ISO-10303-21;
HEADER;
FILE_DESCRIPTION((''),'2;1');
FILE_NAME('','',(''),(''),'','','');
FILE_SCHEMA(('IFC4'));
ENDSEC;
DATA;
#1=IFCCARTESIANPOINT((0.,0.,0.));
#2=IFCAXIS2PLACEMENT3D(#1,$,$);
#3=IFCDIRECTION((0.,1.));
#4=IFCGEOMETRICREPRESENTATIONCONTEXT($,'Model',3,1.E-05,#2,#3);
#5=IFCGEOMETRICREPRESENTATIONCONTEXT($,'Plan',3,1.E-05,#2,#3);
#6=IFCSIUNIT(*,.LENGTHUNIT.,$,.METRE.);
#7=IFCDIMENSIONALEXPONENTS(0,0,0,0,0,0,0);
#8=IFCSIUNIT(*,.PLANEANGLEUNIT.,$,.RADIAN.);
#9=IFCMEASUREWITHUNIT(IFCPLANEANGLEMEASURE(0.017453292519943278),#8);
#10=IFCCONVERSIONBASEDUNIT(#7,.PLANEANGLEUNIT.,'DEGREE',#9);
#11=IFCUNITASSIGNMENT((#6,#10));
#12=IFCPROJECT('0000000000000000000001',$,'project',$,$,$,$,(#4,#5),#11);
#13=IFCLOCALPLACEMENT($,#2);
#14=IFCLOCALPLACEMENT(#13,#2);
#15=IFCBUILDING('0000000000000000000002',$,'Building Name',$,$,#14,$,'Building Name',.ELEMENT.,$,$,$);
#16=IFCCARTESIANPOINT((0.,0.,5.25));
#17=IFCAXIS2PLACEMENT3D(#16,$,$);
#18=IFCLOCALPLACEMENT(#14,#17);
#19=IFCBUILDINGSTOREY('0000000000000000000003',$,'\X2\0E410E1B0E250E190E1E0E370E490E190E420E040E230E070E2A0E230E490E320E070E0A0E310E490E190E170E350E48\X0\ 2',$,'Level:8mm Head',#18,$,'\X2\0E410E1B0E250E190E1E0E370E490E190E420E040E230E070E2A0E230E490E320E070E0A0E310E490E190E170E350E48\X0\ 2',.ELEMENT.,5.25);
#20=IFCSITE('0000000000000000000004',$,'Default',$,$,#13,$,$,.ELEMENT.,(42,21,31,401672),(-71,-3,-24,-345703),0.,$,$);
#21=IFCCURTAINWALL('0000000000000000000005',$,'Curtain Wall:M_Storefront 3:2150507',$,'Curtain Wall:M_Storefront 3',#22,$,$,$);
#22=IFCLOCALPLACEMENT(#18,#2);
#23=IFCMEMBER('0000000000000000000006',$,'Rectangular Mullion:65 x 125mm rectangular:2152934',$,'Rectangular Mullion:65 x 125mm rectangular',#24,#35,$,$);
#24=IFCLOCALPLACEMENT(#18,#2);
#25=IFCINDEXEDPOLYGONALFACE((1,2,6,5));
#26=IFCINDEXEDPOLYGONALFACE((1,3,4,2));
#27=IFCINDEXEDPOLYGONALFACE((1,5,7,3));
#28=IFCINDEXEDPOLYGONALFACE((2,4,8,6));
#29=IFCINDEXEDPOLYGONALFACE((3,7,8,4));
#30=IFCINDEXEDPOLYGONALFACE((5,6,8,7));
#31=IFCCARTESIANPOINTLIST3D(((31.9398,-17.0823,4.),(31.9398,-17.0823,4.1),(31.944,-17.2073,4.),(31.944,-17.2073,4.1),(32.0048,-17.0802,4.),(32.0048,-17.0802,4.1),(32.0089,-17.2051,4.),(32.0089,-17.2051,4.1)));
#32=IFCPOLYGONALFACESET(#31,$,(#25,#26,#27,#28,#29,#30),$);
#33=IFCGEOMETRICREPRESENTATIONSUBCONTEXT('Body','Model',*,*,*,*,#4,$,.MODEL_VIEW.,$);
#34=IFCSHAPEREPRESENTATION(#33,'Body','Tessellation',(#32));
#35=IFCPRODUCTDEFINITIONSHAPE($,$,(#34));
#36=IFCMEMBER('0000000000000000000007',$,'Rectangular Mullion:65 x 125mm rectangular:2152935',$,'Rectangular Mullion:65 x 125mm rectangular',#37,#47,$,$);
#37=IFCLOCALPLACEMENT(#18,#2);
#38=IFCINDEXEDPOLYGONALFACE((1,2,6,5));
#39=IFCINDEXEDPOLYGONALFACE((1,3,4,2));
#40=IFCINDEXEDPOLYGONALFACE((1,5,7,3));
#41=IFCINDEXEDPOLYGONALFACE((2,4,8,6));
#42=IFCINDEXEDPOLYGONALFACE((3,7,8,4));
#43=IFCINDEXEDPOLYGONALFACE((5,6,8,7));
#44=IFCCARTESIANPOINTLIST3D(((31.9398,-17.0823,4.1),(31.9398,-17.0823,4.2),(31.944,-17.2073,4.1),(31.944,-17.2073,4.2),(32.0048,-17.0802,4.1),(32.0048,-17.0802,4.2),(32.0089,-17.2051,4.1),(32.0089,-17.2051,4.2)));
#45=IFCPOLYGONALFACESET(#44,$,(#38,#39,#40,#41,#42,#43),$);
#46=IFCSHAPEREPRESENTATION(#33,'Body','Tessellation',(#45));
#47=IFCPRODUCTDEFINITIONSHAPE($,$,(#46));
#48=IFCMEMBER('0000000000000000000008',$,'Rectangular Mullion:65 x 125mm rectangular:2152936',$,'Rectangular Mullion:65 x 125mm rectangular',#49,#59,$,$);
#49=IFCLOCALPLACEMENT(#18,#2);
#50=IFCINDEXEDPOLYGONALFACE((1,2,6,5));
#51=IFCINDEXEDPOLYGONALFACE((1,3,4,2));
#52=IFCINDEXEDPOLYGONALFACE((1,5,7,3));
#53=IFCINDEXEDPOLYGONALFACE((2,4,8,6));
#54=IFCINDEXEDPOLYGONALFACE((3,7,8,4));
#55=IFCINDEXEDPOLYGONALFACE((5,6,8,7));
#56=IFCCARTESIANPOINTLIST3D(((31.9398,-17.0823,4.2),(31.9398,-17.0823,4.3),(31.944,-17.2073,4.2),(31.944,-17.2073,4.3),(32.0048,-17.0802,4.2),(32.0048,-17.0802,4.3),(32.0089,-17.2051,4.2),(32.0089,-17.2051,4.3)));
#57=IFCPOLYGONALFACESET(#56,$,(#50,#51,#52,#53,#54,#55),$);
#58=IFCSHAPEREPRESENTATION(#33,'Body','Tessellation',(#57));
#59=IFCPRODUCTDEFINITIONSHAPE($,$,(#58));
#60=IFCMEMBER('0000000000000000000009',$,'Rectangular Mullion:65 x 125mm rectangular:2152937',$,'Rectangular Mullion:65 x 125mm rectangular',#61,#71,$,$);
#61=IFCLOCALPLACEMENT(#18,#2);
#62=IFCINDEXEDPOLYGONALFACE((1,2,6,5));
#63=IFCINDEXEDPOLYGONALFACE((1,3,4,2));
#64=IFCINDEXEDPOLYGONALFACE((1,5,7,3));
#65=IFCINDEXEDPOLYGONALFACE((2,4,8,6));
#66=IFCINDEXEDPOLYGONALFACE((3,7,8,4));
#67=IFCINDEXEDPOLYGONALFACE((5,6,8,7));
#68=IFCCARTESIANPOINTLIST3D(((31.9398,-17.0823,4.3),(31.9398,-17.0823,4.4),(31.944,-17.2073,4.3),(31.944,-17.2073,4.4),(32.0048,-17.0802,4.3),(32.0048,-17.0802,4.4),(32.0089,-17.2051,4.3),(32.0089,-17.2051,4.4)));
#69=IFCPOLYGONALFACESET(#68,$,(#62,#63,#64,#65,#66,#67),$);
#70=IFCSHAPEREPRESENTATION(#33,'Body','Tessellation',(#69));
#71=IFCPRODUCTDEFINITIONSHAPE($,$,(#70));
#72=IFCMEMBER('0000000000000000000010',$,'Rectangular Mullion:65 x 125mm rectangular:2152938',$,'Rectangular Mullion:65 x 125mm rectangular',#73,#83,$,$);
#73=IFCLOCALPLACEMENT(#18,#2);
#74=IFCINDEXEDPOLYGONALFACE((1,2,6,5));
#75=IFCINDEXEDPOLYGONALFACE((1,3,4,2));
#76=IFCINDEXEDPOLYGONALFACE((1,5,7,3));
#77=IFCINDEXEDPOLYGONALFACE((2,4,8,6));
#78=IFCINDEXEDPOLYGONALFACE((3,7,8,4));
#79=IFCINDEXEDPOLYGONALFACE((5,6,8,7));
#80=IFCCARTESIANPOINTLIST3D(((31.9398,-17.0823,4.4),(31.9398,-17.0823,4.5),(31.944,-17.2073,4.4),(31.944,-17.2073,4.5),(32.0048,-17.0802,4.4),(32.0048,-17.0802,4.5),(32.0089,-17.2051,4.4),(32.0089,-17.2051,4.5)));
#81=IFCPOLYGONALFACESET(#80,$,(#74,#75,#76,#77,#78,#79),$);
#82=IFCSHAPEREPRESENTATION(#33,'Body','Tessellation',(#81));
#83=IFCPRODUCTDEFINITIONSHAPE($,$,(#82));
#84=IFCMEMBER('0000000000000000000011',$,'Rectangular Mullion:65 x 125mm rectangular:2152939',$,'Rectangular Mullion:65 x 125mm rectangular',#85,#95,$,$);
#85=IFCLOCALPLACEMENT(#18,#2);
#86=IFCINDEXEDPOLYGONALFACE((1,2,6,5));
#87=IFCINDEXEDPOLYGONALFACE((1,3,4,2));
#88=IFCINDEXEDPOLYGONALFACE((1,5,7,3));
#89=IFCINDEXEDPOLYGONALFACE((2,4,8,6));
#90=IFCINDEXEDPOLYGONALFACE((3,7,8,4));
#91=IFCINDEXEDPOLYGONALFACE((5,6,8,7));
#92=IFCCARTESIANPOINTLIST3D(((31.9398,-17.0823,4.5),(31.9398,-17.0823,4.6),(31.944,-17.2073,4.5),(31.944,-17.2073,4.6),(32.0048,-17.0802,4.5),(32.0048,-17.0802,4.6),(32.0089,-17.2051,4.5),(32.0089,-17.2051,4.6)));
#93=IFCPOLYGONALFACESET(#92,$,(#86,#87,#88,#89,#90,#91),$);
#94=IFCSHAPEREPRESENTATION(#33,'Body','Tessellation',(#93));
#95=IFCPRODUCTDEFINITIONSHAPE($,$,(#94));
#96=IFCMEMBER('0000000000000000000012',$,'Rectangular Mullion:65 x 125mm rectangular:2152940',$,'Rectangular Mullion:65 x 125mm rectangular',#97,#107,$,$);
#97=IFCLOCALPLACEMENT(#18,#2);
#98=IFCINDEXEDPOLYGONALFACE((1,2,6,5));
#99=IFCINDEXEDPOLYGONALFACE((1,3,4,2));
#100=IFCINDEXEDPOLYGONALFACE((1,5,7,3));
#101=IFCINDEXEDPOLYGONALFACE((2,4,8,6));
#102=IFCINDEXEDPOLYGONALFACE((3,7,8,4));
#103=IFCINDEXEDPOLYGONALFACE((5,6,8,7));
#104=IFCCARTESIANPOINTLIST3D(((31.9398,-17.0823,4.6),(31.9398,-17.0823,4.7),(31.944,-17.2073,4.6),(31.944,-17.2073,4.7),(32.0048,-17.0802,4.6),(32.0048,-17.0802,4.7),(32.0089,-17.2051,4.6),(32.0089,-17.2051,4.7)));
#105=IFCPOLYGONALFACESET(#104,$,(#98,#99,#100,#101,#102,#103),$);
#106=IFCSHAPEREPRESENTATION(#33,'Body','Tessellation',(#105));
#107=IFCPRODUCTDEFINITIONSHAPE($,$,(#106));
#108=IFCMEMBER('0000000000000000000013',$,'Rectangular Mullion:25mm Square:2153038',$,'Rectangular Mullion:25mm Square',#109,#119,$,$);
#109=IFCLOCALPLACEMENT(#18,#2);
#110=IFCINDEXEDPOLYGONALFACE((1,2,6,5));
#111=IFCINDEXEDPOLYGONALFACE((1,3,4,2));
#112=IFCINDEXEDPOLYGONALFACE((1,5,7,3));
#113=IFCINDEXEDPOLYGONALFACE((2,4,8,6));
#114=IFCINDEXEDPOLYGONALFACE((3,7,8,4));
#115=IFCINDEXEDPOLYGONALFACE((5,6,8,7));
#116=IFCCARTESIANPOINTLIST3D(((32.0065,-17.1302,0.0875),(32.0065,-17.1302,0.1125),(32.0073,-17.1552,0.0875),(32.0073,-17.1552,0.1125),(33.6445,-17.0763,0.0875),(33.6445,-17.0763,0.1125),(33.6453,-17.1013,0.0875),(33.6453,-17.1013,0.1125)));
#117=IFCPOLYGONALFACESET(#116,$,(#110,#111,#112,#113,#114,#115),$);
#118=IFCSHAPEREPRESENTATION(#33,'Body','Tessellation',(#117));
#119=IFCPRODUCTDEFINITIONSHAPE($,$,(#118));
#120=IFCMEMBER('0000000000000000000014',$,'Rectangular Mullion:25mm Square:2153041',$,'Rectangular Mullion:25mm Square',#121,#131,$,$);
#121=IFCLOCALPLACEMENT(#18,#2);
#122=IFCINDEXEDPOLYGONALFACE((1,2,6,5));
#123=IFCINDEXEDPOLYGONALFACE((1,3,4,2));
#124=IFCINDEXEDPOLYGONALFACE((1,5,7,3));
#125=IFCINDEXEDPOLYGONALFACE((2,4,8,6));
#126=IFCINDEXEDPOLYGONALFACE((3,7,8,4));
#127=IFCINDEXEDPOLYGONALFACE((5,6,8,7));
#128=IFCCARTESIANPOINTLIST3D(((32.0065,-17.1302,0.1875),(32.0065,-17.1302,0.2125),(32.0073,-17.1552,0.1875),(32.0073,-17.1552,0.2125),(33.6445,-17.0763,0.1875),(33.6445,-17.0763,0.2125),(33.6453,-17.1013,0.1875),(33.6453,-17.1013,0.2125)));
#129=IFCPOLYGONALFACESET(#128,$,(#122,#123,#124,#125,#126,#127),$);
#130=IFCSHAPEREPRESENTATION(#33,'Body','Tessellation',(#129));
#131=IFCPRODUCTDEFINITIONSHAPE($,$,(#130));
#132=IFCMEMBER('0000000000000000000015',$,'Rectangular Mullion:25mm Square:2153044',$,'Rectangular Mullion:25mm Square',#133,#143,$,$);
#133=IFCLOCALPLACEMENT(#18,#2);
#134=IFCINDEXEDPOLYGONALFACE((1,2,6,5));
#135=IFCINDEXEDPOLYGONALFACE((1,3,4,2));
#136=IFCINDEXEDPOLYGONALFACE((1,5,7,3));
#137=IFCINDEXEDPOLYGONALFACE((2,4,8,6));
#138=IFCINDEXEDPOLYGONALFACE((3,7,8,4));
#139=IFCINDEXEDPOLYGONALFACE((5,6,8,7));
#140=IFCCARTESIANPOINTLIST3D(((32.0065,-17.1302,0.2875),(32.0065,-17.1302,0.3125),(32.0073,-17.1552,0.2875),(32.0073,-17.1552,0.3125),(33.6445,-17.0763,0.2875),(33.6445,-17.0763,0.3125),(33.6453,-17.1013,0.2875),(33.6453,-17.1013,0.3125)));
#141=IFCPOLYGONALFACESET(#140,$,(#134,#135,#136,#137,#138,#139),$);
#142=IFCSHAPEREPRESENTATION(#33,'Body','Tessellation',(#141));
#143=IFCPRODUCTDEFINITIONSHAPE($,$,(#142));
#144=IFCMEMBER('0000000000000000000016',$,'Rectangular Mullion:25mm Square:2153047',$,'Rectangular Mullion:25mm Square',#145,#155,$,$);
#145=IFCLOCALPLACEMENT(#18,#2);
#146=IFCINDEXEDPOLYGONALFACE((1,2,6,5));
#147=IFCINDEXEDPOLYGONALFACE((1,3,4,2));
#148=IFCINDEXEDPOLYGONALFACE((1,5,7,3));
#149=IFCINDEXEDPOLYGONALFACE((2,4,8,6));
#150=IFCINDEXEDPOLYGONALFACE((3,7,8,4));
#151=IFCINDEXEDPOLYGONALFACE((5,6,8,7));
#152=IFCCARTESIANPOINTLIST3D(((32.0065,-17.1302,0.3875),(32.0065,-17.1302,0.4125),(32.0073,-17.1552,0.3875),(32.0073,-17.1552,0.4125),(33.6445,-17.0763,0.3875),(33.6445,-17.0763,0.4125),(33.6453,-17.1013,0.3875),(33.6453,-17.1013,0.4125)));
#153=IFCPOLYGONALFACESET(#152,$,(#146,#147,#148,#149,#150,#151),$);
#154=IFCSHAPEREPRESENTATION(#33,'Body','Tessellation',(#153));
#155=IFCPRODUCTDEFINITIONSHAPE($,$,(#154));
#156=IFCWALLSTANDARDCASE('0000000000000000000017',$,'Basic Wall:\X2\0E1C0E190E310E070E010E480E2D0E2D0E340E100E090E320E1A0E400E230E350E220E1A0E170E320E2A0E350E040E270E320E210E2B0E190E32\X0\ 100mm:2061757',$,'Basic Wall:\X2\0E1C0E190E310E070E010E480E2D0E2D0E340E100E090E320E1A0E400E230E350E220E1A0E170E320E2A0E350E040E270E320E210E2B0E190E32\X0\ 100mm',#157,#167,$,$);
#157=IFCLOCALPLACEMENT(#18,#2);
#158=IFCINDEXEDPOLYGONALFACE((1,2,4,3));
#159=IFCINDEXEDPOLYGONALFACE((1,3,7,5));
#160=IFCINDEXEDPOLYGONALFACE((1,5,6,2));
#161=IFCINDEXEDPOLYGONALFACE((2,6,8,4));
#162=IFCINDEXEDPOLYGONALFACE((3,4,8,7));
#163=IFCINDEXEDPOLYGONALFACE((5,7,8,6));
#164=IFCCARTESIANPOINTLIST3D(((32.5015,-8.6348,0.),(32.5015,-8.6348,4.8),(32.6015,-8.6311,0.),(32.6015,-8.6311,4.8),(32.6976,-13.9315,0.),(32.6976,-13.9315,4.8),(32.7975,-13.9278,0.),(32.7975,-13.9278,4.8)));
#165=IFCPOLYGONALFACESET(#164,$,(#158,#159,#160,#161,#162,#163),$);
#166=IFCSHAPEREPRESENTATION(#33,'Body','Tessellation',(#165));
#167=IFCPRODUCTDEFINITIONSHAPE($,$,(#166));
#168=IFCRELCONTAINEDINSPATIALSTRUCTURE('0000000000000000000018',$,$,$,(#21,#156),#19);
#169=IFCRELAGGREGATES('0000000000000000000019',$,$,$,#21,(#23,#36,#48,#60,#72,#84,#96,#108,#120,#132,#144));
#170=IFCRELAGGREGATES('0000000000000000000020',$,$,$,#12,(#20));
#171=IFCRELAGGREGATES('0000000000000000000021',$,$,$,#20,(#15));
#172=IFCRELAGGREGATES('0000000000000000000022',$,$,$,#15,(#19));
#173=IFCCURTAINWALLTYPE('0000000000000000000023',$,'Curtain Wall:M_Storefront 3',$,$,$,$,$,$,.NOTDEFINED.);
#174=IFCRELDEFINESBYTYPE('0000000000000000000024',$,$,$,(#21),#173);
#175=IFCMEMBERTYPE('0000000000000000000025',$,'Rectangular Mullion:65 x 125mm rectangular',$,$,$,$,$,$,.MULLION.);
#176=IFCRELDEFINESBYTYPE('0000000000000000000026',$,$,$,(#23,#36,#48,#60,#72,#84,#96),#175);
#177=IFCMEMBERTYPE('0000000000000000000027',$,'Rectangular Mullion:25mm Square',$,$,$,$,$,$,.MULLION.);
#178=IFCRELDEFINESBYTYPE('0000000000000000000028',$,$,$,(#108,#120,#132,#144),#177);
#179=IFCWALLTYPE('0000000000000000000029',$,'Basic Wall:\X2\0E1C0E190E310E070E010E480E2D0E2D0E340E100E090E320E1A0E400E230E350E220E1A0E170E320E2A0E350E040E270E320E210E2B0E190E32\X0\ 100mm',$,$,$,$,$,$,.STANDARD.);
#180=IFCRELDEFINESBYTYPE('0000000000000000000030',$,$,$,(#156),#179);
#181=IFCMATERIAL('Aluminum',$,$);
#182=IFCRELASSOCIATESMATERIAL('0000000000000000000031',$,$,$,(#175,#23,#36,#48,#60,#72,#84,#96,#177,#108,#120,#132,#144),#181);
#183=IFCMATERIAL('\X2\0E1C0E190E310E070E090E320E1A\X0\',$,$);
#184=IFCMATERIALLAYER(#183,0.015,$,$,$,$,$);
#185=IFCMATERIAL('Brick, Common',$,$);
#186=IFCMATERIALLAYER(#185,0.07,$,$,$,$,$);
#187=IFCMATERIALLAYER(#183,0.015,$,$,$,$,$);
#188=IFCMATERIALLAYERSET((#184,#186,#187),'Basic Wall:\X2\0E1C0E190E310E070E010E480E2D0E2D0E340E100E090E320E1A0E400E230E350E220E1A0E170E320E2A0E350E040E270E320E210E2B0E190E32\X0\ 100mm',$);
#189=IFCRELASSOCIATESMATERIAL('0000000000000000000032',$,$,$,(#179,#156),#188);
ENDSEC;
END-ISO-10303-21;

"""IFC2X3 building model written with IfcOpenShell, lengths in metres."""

from ifc_helpers import new_model, entity, si_unit, converted_unit, direction, frame, origin, origin_2d_with_axis, place, context, subcontext, project, spatial, polyline, rectangle, outline, extrude, source, transform, mapped, material, layer, layer_set, layer_usage, type_object, type_shapes, element, aggregate, save


model = new_model("IFC2X3")

# Units and contexts
model_context = context("Model", 3, precision=1e-05, world=origin(), true_north=direction((0.0, 1.0)))
plan_context = context("Plan", 3, precision=1e-05, world=origin(), true_north=direction((0.0, 1.0)))
body_context = subcontext(model_context, "Body", "Model", "MODEL_VIEW")
ifc_project = project(units=[si_unit("LENGTHUNIT", "METRE"), converted_unit("PLANEANGLEUNIT", "DEGREE", entity("IfcPlaneAngleMeasure", 0.017453292519943278), si_unit("PLANEANGLEUNIT", "RADIAN"), dimensions=[0, 0, 0, 0, 0, 0, 0])], contexts=[model_context, plan_context])

# Site, building, storey
site_placement = place(None, origin())
site = spatial("IfcSite", under=ifc_project, at=site_placement, Name="Default", CompositionType="ELEMENT", RefLatitude=(42, 21, 31, 401672), RefLongitude=(-71, -3, -24, -345703), RefElevation=0.0)
building_placement = place(site_placement, origin())
building = spatial("IfcBuilding", under=site, at=building_placement, Name="Building Name", LongName="Building Name", CompositionType="ELEMENT")
storey_placement = place(building_placement, frame((0.0, 0.0, 5.25)))
storey = spatial("IfcBuildingStorey", under=building, at=storey_placement, Name="แปลนพื้นโครงสร้างชั้นที่ 2", ObjectType="Level:8mm Head", LongName="แปลนพื้นโครงสร้างชั้นที่ 2", CompositionType="ELEMENT", Elevation=5.25)

# Curtain wall, members
curtain_wall_type = type_object("IfcCurtainWallType", Name="Curtain Wall:M_Storefront 3", PredefinedType="NOTDEFINED")
curtain_wall_placement = place(storey_placement, frame((0.0, 0.0, -5.25)))
curtain_wall = element("IfcCurtainWall", 1, at=curtain_wall_placement, inside=storey, type_object=curtain_wall_type, Name="Curtain Wall:M_Storefront 3:2150507", ObjectType="Curtain Wall:M_Storefront 3")
ifc_material_1 = material(Name="Aluminum")
member_type_1 = type_object("IfcMemberType", Name="Rectangular Mullion:65 x 125mm rectangular", PredefinedType="MULLION", material=ifc_material_1)
shared_shape_1 = source(origin(), body_context, "Body", "SweptSolid", [
    extrude(rectangle(XDim=0.065, YDim=0.125, at=origin_2d_with_axis()), frame((-0.0325, 0.0, -0.1), z_axis=(0.0, 0.0, 1.0), x_axis=(-1.0, 0.0, 0.0)), (0.0, 0.0, 1.0), 0.1),
])
type_shapes(member_type_1, [shared_shape_1])
member_1_placement = place(curtain_wall_placement, frame((31.9419, -17.1448, 9.35), z_axis=(0.0, 0.0, 1.0), x_axis=(-0.99946, -0.032862, 0.0)))
member_1 = element("IfcMember", 2, at=member_1_placement, type_object=member_type_1, material=ifc_material_1, Name="Rectangular Mullion:65 x 125mm rectangular:2152934", ObjectType="Rectangular Mullion:65 x 125mm rectangular", context=body_context, shape_type="MappedRepresentation", body=[
    mapped(shared_shape_1, transform((0.0, 0.0, 0.0), scale=1.0)),
])
member_2_placement = place(curtain_wall_placement, frame((31.9419, -17.1448, 9.45), z_axis=(0.0, 0.0, 1.0), x_axis=(-0.99946, -0.032862, 0.0)))
member_2 = element("IfcMember", 3, at=member_2_placement, type_object=member_type_1, material=ifc_material_1, Name="Rectangular Mullion:65 x 125mm rectangular:2152935", ObjectType="Rectangular Mullion:65 x 125mm rectangular", context=body_context, shape_type="MappedRepresentation", body=[
    mapped(shared_shape_1, transform((0.0, 0.0, 0.0), scale=1.0)),
])
member_3_placement = place(curtain_wall_placement, frame((31.9419, -17.1448, 9.55), z_axis=(0.0, 0.0, 1.0), x_axis=(-0.99946, -0.032862, 0.0)))
member_3 = element("IfcMember", 4, at=member_3_placement, type_object=member_type_1, material=ifc_material_1, Name="Rectangular Mullion:65 x 125mm rectangular:2152936", ObjectType="Rectangular Mullion:65 x 125mm rectangular", context=body_context, shape_type="MappedRepresentation", body=[
    mapped(shared_shape_1, transform((0.0, 0.0, 0.0), scale=1.0)),
])
member_4_placement = place(curtain_wall_placement, frame((31.9419, -17.1448, 9.65), z_axis=(0.0, 0.0, 1.0), x_axis=(-0.99946, -0.032862, 0.0)))
member_4 = element("IfcMember", 5, at=member_4_placement, type_object=member_type_1, material=ifc_material_1, Name="Rectangular Mullion:65 x 125mm rectangular:2152937", ObjectType="Rectangular Mullion:65 x 125mm rectangular", context=body_context, shape_type="MappedRepresentation", body=[
    mapped(shared_shape_1, transform((0.0, 0.0, 0.0), scale=1.0)),
])
member_5_placement = place(curtain_wall_placement, frame((31.9419, -17.1448, 9.75), z_axis=(0.0, 0.0, 1.0), x_axis=(-0.99946, -0.032862, 0.0)))
member_5 = element("IfcMember", 6, at=member_5_placement, type_object=member_type_1, material=ifc_material_1, Name="Rectangular Mullion:65 x 125mm rectangular:2152938", ObjectType="Rectangular Mullion:65 x 125mm rectangular", context=body_context, shape_type="MappedRepresentation", body=[
    mapped(shared_shape_1, transform((0.0, 0.0, 0.0), scale=1.0)),
])
member_6_placement = place(curtain_wall_placement, frame((31.9419, -17.1448, 9.85), z_axis=(0.0, 0.0, 1.0), x_axis=(-0.99946, -0.032862, 0.0)))
member_6 = element("IfcMember", 7, at=member_6_placement, type_object=member_type_1, material=ifc_material_1, Name="Rectangular Mullion:65 x 125mm rectangular:2152939", ObjectType="Rectangular Mullion:65 x 125mm rectangular", context=body_context, shape_type="MappedRepresentation", body=[
    mapped(shared_shape_1, transform((0.0, 0.0, 0.0), scale=1.0)),
])
member_7_placement = place(curtain_wall_placement, frame((31.9419, -17.1448, 9.95), z_axis=(0.0, 0.0, 1.0), x_axis=(-0.99946, -0.032862, 0.0)))
member_7 = element("IfcMember", 8, at=member_7_placement, type_object=member_type_1, material=ifc_material_1, Name="Rectangular Mullion:65 x 125mm rectangular:2152940", ObjectType="Rectangular Mullion:65 x 125mm rectangular", context=body_context, shape_type="MappedRepresentation", body=[
    mapped(shared_shape_1, transform((0.0, 0.0, 0.0), scale=1.0)),
])
member_type_2 = type_object("IfcMemberType", Name="Rectangular Mullion:25mm Square", PredefinedType="MULLION", material=ifc_material_1)
shared_shape_2 = source(origin(), body_context, "Body", "SweptSolid", [
    extrude(rectangle(XDim=0.025, YDim=0.025, at=origin_2d_with_axis()), frame((0.0, 0.0, -1.6389), z_axis=(0.0, 0.0, 1.0), x_axis=(-1.0, 0.0, 0.0)), (0.0, 0.0, 1.0), 1.6389),
])
type_shapes(member_type_2, [shared_shape_2])
member_8_placement = place(curtain_wall_placement, frame((33.6449, -17.0888, 5.35), z_axis=(0.99946, 0.032862, 0.0), x_axis=(0.0, 0.0, 1.0)))
member_8 = element("IfcMember", 9, at=member_8_placement, type_object=member_type_2, material=ifc_material_1, Name="Rectangular Mullion:25mm Square:2153038", ObjectType="Rectangular Mullion:25mm Square", context=body_context, shape_type="MappedRepresentation", body=[
    mapped(shared_shape_2, transform((0.0, 0.0, 0.0), scale=1.0)),
])
member_9_placement = place(curtain_wall_placement, frame((33.6449, -17.0888, 5.45), z_axis=(0.99946, 0.032862, 0.0), x_axis=(0.0, 0.0, 1.0)))
member_9 = element("IfcMember", 10, at=member_9_placement, type_object=member_type_2, material=ifc_material_1, Name="Rectangular Mullion:25mm Square:2153041", ObjectType="Rectangular Mullion:25mm Square", context=body_context, shape_type="MappedRepresentation", body=[
    mapped(shared_shape_2, transform((0.0, 0.0, 0.0), scale=1.0)),
])
member_10_placement = place(curtain_wall_placement, frame((33.6449, -17.0888, 5.55), z_axis=(0.99946, 0.032862, 0.0), x_axis=(0.0, 0.0, 1.0)))
member_10 = element("IfcMember", 11, at=member_10_placement, type_object=member_type_2, material=ifc_material_1, Name="Rectangular Mullion:25mm Square:2153044", ObjectType="Rectangular Mullion:25mm Square", context=body_context, shape_type="MappedRepresentation", body=[
    mapped(shared_shape_2, transform((0.0, 0.0, 0.0), scale=1.0)),
])
member_11_placement = place(curtain_wall_placement, frame((33.6449, -17.0888, 5.65), z_axis=(0.99946, 0.032862, 0.0), x_axis=(0.0, 0.0, 1.0)))
member_11 = element("IfcMember", 12, at=member_11_placement, type_object=member_type_2, material=ifc_material_1, Name="Rectangular Mullion:25mm Square:2153047", ObjectType="Rectangular Mullion:25mm Square", context=body_context, shape_type="MappedRepresentation", body=[
    mapped(shared_shape_2, transform((0.0, 0.0, 0.0), scale=1.0)),
])
aggregate(curtain_wall, [member_1, member_2, member_3, member_4, member_5, member_6, member_7, member_8, member_9, member_10, member_11])

# Wall
ifc_material_2 = material(Name="ผนังฉาบ")
ifc_layer_1 = layer(ifc_material_2, 0.015)
ifc_material_3 = material(Name="Brick, Common")
ifc_layer_2 = layer(ifc_material_3, 0.07)
ifc_layer_3 = layer(ifc_material_2, 0.015)
ifc_layer_set = layer_set([ifc_layer_1, ifc_layer_2, ifc_layer_3], Name="Basic Wall:ผนังก่ออิฐฉาบเรียบทาสีความหนา 100mm")
ifc_layer_usage = layer_usage(ifc_layer_set, "AXIS2", "NEGATIVE", 0.05)
wall_type = type_object("IfcWallType", Name="Basic Wall:ผนังก่ออิฐฉาบเรียบทาสีความหนา 100mm", PredefinedType="STANDARD", material=ifc_layer_set)
wall_placement = place(storey_placement, frame((32.7476, -13.9296, 0.0), z_axis=(0.0, 0.0, 1.0), x_axis=(-0.036993, 0.999316, 0.0)))
element("IfcWallStandardCase", 13, at=wall_placement, inside=storey, type_object=wall_type, material=ifc_layer_usage, Name="Basic Wall:ผนังก่ออิฐฉาบเรียบทาสีความหนา 100mm:2061757", ObjectType="Basic Wall:ผนังก่ออิฐฉาบเรียบทาสีความหนา 100mm", context=body_context, shape_type="SweptSolid", body=[
    extrude(outline(polyline([(5.3004, -0.05), (5.3003, 0.05), (0.0, 0.05), (0.0, -0.05), (5.3004, -0.05)])), origin(), (0.0, 0.0, 1.0), 4.8),
])

save(model, "model.ifc")
